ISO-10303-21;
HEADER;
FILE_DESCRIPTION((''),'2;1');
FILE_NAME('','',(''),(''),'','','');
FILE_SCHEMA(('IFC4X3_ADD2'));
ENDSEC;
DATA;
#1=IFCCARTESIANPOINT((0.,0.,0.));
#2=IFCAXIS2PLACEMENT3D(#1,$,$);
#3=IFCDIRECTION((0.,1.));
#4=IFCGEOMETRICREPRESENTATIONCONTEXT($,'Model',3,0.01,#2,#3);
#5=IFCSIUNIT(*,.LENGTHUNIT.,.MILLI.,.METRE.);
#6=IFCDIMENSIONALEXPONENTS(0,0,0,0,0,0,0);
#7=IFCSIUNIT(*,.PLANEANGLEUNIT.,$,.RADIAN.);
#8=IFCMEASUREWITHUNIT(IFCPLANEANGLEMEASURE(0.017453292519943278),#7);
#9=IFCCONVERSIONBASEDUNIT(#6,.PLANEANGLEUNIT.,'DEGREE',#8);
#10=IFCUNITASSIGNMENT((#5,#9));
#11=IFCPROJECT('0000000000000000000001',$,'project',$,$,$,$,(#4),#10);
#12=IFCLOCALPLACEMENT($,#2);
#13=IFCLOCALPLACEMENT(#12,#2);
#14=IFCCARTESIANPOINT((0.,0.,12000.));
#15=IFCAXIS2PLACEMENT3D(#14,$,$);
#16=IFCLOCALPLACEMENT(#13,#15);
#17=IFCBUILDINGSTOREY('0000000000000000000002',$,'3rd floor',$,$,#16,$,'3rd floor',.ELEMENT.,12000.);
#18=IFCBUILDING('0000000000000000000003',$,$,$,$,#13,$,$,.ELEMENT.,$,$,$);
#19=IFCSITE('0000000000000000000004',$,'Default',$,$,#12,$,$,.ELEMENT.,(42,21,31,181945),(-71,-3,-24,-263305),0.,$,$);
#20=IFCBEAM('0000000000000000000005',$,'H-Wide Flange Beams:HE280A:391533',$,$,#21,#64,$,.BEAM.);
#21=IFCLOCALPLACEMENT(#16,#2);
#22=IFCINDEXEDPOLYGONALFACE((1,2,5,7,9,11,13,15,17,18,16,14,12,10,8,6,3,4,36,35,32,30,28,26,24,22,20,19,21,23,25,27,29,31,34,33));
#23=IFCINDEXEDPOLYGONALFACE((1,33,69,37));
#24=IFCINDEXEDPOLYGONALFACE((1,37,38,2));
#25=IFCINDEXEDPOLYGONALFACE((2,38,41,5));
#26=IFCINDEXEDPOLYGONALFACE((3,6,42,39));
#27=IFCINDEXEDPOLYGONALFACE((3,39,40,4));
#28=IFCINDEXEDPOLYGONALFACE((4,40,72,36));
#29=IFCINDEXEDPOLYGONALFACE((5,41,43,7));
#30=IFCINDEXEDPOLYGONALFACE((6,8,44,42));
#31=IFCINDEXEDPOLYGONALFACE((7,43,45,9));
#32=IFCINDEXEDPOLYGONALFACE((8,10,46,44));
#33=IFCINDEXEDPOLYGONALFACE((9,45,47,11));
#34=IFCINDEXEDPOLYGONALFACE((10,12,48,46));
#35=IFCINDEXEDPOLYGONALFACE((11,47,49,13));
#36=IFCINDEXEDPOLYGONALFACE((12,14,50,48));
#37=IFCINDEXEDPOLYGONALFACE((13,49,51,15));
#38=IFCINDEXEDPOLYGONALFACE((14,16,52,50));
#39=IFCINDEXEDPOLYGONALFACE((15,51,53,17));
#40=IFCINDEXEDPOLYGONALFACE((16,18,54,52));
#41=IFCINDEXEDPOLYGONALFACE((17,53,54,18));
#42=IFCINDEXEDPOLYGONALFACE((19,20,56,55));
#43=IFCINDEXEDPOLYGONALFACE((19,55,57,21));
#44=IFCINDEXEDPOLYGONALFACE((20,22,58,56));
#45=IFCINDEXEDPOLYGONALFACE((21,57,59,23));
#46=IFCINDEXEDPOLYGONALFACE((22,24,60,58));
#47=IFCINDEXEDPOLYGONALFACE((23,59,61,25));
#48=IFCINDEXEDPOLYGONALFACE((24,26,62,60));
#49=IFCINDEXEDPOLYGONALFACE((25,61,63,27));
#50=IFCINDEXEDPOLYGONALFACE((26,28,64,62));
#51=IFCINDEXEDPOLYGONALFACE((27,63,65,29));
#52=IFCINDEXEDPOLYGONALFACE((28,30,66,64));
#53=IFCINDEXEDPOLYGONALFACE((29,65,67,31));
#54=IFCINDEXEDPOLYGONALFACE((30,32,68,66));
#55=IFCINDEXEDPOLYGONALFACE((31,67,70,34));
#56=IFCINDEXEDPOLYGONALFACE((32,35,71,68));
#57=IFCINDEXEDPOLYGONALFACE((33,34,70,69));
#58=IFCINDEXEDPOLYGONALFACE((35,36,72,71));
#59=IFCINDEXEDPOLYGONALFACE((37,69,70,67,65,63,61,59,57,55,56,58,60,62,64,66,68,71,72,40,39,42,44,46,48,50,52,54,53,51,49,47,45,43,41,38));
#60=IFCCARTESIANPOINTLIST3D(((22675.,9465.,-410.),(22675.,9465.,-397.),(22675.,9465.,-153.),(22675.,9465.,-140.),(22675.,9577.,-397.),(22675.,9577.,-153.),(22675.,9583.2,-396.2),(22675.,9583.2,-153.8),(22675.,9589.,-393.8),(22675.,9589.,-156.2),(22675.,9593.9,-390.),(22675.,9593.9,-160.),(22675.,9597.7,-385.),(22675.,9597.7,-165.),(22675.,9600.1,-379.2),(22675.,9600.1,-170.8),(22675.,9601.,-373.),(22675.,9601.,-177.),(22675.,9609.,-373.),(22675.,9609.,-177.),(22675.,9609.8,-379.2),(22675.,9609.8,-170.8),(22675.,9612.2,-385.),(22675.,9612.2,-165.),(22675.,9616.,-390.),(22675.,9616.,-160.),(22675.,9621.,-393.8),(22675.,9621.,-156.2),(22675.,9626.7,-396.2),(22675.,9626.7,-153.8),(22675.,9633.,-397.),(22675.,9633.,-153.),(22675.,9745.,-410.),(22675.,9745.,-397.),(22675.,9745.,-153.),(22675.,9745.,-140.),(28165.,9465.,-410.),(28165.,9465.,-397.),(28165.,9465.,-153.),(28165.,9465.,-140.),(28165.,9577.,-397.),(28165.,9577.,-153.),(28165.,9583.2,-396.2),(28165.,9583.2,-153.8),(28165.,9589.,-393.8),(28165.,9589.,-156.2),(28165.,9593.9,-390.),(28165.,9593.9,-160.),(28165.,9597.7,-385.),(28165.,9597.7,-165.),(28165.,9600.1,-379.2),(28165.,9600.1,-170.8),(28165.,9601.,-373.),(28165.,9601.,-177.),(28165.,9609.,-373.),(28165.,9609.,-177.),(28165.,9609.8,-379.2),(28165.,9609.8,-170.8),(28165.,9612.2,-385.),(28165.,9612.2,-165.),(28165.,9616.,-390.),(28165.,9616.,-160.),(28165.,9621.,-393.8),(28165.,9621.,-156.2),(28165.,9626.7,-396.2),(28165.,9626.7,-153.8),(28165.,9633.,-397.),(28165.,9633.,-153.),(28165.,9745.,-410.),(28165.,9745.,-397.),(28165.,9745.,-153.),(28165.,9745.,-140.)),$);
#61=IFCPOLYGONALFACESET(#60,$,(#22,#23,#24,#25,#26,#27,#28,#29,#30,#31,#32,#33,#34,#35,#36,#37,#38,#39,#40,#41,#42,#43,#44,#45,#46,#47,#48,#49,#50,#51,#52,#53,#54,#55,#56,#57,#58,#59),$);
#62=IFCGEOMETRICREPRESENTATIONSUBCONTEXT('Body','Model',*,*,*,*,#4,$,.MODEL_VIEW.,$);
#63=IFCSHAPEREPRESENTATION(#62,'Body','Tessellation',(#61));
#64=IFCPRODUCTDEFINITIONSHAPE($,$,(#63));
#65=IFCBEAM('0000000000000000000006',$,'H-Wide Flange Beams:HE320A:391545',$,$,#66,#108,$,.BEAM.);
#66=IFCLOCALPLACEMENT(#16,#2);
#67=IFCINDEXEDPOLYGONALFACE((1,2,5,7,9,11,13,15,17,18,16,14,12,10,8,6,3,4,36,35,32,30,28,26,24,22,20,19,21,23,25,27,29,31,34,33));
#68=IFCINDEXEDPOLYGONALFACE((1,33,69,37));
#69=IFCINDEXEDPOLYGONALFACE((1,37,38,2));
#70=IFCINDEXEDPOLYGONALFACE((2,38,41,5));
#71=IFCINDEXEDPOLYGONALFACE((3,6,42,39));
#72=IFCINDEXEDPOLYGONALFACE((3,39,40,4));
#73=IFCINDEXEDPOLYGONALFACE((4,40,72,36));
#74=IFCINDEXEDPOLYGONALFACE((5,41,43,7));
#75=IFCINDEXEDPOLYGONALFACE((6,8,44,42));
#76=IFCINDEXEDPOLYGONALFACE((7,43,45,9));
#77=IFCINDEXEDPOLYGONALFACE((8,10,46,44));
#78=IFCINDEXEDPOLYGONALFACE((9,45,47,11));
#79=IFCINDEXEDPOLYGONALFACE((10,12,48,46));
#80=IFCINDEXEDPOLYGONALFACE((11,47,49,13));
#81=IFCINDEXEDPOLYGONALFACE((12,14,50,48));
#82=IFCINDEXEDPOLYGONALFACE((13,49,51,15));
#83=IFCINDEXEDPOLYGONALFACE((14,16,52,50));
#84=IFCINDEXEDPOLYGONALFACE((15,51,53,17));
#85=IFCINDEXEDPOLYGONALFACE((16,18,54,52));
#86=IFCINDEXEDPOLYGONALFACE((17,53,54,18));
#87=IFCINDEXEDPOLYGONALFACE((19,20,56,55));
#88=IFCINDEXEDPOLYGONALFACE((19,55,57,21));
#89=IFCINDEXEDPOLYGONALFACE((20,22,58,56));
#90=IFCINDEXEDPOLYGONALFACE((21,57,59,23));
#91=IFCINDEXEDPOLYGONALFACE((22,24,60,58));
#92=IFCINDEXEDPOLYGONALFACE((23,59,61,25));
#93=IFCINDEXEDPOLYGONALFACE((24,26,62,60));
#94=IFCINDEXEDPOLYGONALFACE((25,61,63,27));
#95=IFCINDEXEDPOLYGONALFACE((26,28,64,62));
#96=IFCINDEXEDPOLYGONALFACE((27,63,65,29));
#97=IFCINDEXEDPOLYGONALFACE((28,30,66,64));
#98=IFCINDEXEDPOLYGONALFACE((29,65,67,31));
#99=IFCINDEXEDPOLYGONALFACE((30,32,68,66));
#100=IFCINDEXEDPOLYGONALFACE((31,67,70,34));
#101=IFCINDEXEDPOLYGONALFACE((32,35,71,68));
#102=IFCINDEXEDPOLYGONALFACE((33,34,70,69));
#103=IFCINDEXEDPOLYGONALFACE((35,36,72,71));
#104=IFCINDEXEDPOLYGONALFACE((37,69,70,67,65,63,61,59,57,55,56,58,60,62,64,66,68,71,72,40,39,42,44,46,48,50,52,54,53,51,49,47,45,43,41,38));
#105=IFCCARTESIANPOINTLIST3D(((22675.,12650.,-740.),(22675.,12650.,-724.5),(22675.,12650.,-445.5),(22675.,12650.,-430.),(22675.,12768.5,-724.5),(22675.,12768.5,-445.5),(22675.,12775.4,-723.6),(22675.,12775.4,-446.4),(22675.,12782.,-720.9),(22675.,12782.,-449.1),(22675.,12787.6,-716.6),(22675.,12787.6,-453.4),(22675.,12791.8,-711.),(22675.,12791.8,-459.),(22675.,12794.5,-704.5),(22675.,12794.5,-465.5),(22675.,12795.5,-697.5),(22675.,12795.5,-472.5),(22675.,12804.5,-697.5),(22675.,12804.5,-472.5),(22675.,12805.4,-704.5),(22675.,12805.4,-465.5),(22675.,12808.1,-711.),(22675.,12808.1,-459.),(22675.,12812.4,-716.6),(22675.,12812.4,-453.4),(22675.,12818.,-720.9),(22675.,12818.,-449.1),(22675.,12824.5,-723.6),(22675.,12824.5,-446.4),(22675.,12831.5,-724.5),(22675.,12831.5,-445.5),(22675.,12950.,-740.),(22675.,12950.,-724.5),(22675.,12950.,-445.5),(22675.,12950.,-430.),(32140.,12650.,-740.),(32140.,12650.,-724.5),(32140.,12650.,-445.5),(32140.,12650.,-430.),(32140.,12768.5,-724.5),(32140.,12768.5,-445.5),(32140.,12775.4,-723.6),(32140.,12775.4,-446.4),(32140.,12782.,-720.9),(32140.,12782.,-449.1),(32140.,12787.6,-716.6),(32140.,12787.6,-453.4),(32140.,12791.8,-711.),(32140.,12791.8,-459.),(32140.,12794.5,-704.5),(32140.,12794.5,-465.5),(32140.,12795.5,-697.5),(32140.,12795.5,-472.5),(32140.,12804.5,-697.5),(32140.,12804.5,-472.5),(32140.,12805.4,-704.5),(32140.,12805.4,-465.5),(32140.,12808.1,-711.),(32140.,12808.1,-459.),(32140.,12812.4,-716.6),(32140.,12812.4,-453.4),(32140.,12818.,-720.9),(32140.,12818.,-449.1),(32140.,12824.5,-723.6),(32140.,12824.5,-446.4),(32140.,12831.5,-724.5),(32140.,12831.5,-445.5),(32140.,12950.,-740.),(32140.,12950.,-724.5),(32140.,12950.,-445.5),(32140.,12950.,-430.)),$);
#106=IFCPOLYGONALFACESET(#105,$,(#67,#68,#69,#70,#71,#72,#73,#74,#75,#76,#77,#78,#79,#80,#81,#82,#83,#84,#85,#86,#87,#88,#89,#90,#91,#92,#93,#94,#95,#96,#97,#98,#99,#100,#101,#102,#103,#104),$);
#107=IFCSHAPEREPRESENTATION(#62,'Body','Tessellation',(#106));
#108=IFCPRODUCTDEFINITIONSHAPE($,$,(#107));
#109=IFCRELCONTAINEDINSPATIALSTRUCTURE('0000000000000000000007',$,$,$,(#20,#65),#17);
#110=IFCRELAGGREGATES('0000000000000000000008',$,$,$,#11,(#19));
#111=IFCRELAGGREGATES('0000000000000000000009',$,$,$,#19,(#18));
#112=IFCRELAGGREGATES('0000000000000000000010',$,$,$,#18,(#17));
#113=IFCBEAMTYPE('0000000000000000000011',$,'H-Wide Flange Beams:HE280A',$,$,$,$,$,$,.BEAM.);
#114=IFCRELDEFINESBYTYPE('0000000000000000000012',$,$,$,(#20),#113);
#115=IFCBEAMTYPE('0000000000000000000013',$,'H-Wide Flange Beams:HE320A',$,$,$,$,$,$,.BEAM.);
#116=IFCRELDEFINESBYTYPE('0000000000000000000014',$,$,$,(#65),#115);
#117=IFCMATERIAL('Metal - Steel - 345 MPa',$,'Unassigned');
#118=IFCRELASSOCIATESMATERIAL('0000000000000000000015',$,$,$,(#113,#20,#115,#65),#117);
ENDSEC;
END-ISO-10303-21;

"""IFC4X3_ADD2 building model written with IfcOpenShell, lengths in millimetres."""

from ifc_helpers import new_model, entity, si_unit, converted_unit, direction, frame, frame_2d, origin, place, context, subcontext, project, spatial, polyline, circle_curve, parameter, trimmed, segment, composite_curve, outline, extrude, source, transform, mapped, material, material_profile, profile_set, profile_usage, type_object, type_shapes, element, save


model = new_model("IFC4X3_ADD2")

# Units and contexts
model_context = context("Model", 3, precision=0.01, world=origin(), true_north=direction((0.0, 1.0)))
body_context = subcontext(model_context, "Body", "Model", "MODEL_VIEW")
ifc_project = project(units=[si_unit("LENGTHUNIT", "METRE", prefix="MILLI"), converted_unit("PLANEANGLEUNIT", "DEGREE", entity("IfcPlaneAngleMeasure", 0.017453292519943278), si_unit("PLANEANGLEUNIT", "RADIAN"), dimensions=[0, 0, 0, 0, 0, 0, 0])], contexts=[model_context])

# Site, building, storey
site_placement = place(None, origin())
site = spatial("IfcSite", under=ifc_project, at=site_placement, Name="Default", CompositionType="ELEMENT", RefLatitude=(42, 21, 31, 181945), RefLongitude=(-71, -3, -24, -263305), RefElevation=0.0)
building_placement = place(site_placement, origin())
building = spatial("IfcBuilding", under=site, at=building_placement, CompositionType="ELEMENT")
storey_placement = place(building_placement, frame((0.0, 0.0, 12000.0)))
storey = spatial("IfcBuildingStorey", under=building, at=storey_placement, Name="3rd floor", LongName="3rd floor", CompositionType="ELEMENT", Elevation=12000.0)

# Beams
ifc_material_1 = material(Name="Metal - Steel - 345 MPa", Category="Unassigned")
ifc_material_profile_1 = material_profile(ifc_material_1, outline(composite_curve([segment(polyline([(-140.0, -122.0), (-140.0, -135.0)]), True, "CONTINUOUS"), segment(polyline([(-140.0, -135.0), (140.0, -135.0)]), True, "CONTINUOUS"), segment(polyline([(140.0, -135.0), (140.0, -122.0)]), True, "CONTINUOUS"), segment(polyline([(140.0, -122.0), (28.0, -122.0)]), True, "CONTINUOUS"), segment(trimmed(circle_curve(frame_2d((28.0, -98.0), x_axis=(1.0, 0.0)), 24.0), [parameter(180.0)], [parameter(270.0)], True, "PARAMETER"), False, "CONTINUOUS"), segment(polyline([(4.0, -98.0), (4.0, 98.0)]), True, "CONTINUOUS"), segment(trimmed(circle_curve(frame_2d((28.0, 98.0), x_axis=(1.0, 0.0)), 24.0), [parameter(90.0)], [parameter(180.0)], True, "PARAMETER"), False, "CONTINUOUS"), segment(polyline([(28.0, 122.0), (140.0, 122.0)]), True, "CONTINUOUS"), segment(polyline([(140.0, 122.0), (140.0, 135.0)]), True, "CONTINUOUS"), segment(polyline([(140.0, 135.0), (-140.0, 135.0)]), True, "CONTINUOUS"), segment(polyline([(-140.0, 135.0), (-140.0, 122.0)]), True, "CONTINUOUS"), segment(polyline([(-140.0, 122.0), (-28.0, 122.0)]), True, "CONTINUOUS"), segment(trimmed(circle_curve(frame_2d((-28.0, 98.0), x_axis=(1.0, 0.0)), 24.0), [parameter(360.0)], [parameter(90.0)], True, "PARAMETER"), False, "CONTINUOUS"), segment(polyline([(-4.0, 98.0), (-4.0, -98.0)]), True, "CONTINUOUS"), segment(trimmed(circle_curve(frame_2d((-28.0, -98.0), x_axis=(1.0, 0.0)), 24.0), [parameter(270.0)], [parameter(360.0)], True, "PARAMETER"), False, "CONTINUOUS"), segment(polyline([(-28.0, -122.0), (-140.0, -122.0)]), True, "CONTINUOUS")], self_intersect=False)), Name="HE280A")
ifc_profile_set_1 = profile_set([ifc_material_profile_1], Name="HE280A")
ifc_profile_usage_1 = profile_usage(ifc_profile_set_1, cardinal=8)
beam_type_1 = type_object("IfcBeamType", Name="H-Wide Flange Beams:HE280A", PredefinedType="BEAM", material=ifc_profile_set_1)
shared_shape_1 = source(origin(), body_context, "Body", "SweptSolid", [
    extrude(outline(composite_curve([segment(polyline([(-140.0, -122.0), (-140.0, -135.0)]), True, "CONTINUOUS"), segment(polyline([(-140.0, -135.0), (140.0, -135.0)]), True, "CONTINUOUS"), segment(polyline([(140.0, -135.0), (140.0, -122.0)]), True, "CONTINUOUS"), segment(polyline([(140.0, -122.0), (28.0, -122.0)]), True, "CONTINUOUS"), segment(trimmed(circle_curve(frame_2d((28.0, -98.0), x_axis=(1.0, 0.0)), 24.0), [parameter(180.0)], [parameter(270.0)], True, "PARAMETER"), False, "CONTINUOUS"), segment(polyline([(4.0, -98.0), (4.0, 98.0)]), True, "CONTINUOUS"), segment(trimmed(circle_curve(frame_2d((28.0, 98.0), x_axis=(1.0, 0.0)), 24.0), [parameter(90.0)], [parameter(180.0)], True, "PARAMETER"), False, "CONTINUOUS"), segment(polyline([(28.0, 122.0), (140.0, 122.0)]), True, "CONTINUOUS"), segment(polyline([(140.0, 122.0), (140.0, 135.0)]), True, "CONTINUOUS"), segment(polyline([(140.0, 135.0), (-140.0, 135.0)]), True, "CONTINUOUS"), segment(polyline([(-140.0, 135.0), (-140.0, 122.0)]), True, "CONTINUOUS"), segment(polyline([(-140.0, 122.0), (-28.0, 122.0)]), True, "CONTINUOUS"), segment(trimmed(circle_curve(frame_2d((-28.0, 98.0), x_axis=(1.0, 0.0)), 24.0), [parameter(360.0)], [parameter(90.0)], True, "PARAMETER"), False, "CONTINUOUS"), segment(polyline([(-4.0, 98.0), (-4.0, -98.0)]), True, "CONTINUOUS"), segment(trimmed(circle_curve(frame_2d((-28.0, -98.0), x_axis=(1.0, 0.0)), 24.0), [parameter(270.0)], [parameter(360.0)], True, "PARAMETER"), False, "CONTINUOUS"), segment(polyline([(-28.0, -122.0), (-140.0, -122.0)]), True, "CONTINUOUS")], self_intersect=False)), frame((-2540.0, 0.0, 0.0), z_axis=(-1.0, 0.0, 0.0), x_axis=(0.0, -1.0, 0.0)), (0.0, 0.0, -1.0), 5490.0),
])
type_shapes(beam_type_1, [shared_shape_1])
beam_1_placement = place(storey_placement, frame((25625.0, 9605.0, -275.0), z_axis=(0.0, 0.0, 1.0), x_axis=(-1.0, 0.0, 0.0)))
element("IfcBeam", 1, at=beam_1_placement, inside=storey, type_object=beam_type_1, material=ifc_profile_usage_1, Name="H-Wide Flange Beams:HE280A:391533", PredefinedType="BEAM", context=body_context, shape_type="MappedRepresentation", body=[
    mapped(shared_shape_1, transform((0.0, 0.0, 0.0), scale=1.0)),
])
ifc_material_profile_2 = material_profile(ifc_material_1, outline(composite_curve([segment(polyline([(-150.0, -139.5), (-150.0, -155.0)]), True, "CONTINUOUS"), segment(polyline([(-150.0, -155.0), (150.0, -155.0)]), True, "CONTINUOUS"), segment(polyline([(150.0, -155.0), (150.0, -139.5)]), True, "CONTINUOUS"), segment(polyline([(150.0, -139.5), (31.5, -139.5)]), True, "CONTINUOUS"), segment(trimmed(circle_curve(frame_2d((31.5, -112.5), x_axis=(1.0, 0.0)), 27.0), [parameter(180.0)], [parameter(270.0)], True, "PARAMETER"), False, "CONTINUOUS"), segment(polyline([(4.5, -112.5), (4.5, 112.5)]), True, "CONTINUOUS"), segment(trimmed(circle_curve(frame_2d((31.5, 112.5), x_axis=(1.0, 0.0)), 27.0), [parameter(90.0)], [parameter(180.0)], True, "PARAMETER"), False, "CONTINUOUS"), segment(polyline([(31.5, 139.5), (150.0, 139.5)]), True, "CONTINUOUS"), segment(polyline([(150.0, 139.5), (150.0, 155.0)]), True, "CONTINUOUS"), segment(polyline([(150.0, 155.0), (-150.0, 155.0)]), True, "CONTINUOUS"), segment(polyline([(-150.0, 155.0), (-150.0, 139.5)]), True, "CONTINUOUS"), segment(polyline([(-150.0, 139.5), (-31.5, 139.5)]), True, "CONTINUOUS"), segment(trimmed(circle_curve(frame_2d((-31.5, 112.5), x_axis=(1.0, 0.0)), 27.0), [parameter(360.0)], [parameter(90.0)], True, "PARAMETER"), False, "CONTINUOUS"), segment(polyline([(-4.5, 112.5), (-4.5, -112.5)]), True, "CONTINUOUS"), segment(trimmed(circle_curve(frame_2d((-31.5, -112.5), x_axis=(1.0, 0.0)), 27.0), [parameter(270.0)], [parameter(360.0)], True, "PARAMETER"), False, "CONTINUOUS"), segment(polyline([(-31.5, -139.5), (-150.0, -139.5)]), True, "CONTINUOUS")], self_intersect=False)), Name="HE320A")
ifc_profile_set_2 = profile_set([ifc_material_profile_2], Name="HE320A")
ifc_profile_usage_2 = profile_usage(ifc_profile_set_2, cardinal=8)
beam_type_2 = type_object("IfcBeamType", Name="H-Wide Flange Beams:HE320A", PredefinedType="BEAM", material=ifc_profile_set_2)
shared_shape_2 = source(origin(), body_context, "Body", "SweptSolid", [
    extrude(outline(composite_curve([segment(polyline([(-150.0, -139.5), (-150.0, -155.0)]), True, "CONTINUOUS"), segment(polyline([(-150.0, -155.0), (150.0, -155.0)]), True, "CONTINUOUS"), segment(polyline([(150.0, -155.0), (150.0, -139.5)]), True, "CONTINUOUS"), segment(polyline([(150.0, -139.5), (31.5, -139.5)]), True, "CONTINUOUS"), segment(trimmed(circle_curve(frame_2d((31.5, -112.5), x_axis=(1.0, 0.0)), 27.0), [parameter(180.0)], [parameter(270.0)], True, "PARAMETER"), False, "CONTINUOUS"), segment(polyline([(4.5, -112.5), (4.5, 112.5)]), True, "CONTINUOUS"), segment(trimmed(circle_curve(frame_2d((31.5, 112.5), x_axis=(1.0, 0.0)), 27.0), [parameter(90.0)], [parameter(180.0)], True, "PARAMETER"), False, "CONTINUOUS"), segment(polyline([(31.5, 139.5), (150.0, 139.5)]), True, "CONTINUOUS"), segment(polyline([(150.0, 139.5), (150.0, 155.0)]), True, "CONTINUOUS"), segment(polyline([(150.0, 155.0), (-150.0, 155.0)]), True, "CONTINUOUS"), segment(polyline([(-150.0, 155.0), (-150.0, 139.5)]), True, "CONTINUOUS"), segment(polyline([(-150.0, 139.5), (-31.5, 139.5)]), True, "CONTINUOUS"), segment(trimmed(circle_curve(frame_2d((-31.5, 112.5), x_axis=(1.0, 0.0)), 27.0), [parameter(360.0)], [parameter(90.0)], True, "PARAMETER"), False, "CONTINUOUS"), segment(polyline([(-4.5, 112.5), (-4.5, -112.5)]), True, "CONTINUOUS"), segment(trimmed(circle_curve(frame_2d((-31.5, -112.5), x_axis=(1.0, 0.0)), 27.0), [parameter(270.0)], [parameter(360.0)], True, "PARAMETER"), False, "CONTINUOUS"), segment(polyline([(-31.5, -139.5), (-150.0, -139.5)]), True, "CONTINUOUS")], self_intersect=False)), frame((-4677.5, 0.0, 0.0), z_axis=(-1.0, 0.0, 0.0), x_axis=(0.0, -1.0, 0.0)), (0.0, 0.0, -1.0), 9465.0),
])
type_shapes(beam_type_2, [shared_shape_2])
beam_2_placement = place(storey_placement, frame((27462.5, 12800.0, -585.0), z_axis=(0.0, 0.0, 1.0), x_axis=(-1.0, 0.0, 0.0)))
element("IfcBeam", 2, at=beam_2_placement, inside=storey, type_object=beam_type_2, material=ifc_profile_usage_2, Name="H-Wide Flange Beams:HE320A:391545", PredefinedType="BEAM", context=body_context, shape_type="MappedRepresentation", body=[
    mapped(shared_shape_2, transform((0.0, 0.0, 0.0), scale=1.0)),
])

save(model, "model.ifc")
